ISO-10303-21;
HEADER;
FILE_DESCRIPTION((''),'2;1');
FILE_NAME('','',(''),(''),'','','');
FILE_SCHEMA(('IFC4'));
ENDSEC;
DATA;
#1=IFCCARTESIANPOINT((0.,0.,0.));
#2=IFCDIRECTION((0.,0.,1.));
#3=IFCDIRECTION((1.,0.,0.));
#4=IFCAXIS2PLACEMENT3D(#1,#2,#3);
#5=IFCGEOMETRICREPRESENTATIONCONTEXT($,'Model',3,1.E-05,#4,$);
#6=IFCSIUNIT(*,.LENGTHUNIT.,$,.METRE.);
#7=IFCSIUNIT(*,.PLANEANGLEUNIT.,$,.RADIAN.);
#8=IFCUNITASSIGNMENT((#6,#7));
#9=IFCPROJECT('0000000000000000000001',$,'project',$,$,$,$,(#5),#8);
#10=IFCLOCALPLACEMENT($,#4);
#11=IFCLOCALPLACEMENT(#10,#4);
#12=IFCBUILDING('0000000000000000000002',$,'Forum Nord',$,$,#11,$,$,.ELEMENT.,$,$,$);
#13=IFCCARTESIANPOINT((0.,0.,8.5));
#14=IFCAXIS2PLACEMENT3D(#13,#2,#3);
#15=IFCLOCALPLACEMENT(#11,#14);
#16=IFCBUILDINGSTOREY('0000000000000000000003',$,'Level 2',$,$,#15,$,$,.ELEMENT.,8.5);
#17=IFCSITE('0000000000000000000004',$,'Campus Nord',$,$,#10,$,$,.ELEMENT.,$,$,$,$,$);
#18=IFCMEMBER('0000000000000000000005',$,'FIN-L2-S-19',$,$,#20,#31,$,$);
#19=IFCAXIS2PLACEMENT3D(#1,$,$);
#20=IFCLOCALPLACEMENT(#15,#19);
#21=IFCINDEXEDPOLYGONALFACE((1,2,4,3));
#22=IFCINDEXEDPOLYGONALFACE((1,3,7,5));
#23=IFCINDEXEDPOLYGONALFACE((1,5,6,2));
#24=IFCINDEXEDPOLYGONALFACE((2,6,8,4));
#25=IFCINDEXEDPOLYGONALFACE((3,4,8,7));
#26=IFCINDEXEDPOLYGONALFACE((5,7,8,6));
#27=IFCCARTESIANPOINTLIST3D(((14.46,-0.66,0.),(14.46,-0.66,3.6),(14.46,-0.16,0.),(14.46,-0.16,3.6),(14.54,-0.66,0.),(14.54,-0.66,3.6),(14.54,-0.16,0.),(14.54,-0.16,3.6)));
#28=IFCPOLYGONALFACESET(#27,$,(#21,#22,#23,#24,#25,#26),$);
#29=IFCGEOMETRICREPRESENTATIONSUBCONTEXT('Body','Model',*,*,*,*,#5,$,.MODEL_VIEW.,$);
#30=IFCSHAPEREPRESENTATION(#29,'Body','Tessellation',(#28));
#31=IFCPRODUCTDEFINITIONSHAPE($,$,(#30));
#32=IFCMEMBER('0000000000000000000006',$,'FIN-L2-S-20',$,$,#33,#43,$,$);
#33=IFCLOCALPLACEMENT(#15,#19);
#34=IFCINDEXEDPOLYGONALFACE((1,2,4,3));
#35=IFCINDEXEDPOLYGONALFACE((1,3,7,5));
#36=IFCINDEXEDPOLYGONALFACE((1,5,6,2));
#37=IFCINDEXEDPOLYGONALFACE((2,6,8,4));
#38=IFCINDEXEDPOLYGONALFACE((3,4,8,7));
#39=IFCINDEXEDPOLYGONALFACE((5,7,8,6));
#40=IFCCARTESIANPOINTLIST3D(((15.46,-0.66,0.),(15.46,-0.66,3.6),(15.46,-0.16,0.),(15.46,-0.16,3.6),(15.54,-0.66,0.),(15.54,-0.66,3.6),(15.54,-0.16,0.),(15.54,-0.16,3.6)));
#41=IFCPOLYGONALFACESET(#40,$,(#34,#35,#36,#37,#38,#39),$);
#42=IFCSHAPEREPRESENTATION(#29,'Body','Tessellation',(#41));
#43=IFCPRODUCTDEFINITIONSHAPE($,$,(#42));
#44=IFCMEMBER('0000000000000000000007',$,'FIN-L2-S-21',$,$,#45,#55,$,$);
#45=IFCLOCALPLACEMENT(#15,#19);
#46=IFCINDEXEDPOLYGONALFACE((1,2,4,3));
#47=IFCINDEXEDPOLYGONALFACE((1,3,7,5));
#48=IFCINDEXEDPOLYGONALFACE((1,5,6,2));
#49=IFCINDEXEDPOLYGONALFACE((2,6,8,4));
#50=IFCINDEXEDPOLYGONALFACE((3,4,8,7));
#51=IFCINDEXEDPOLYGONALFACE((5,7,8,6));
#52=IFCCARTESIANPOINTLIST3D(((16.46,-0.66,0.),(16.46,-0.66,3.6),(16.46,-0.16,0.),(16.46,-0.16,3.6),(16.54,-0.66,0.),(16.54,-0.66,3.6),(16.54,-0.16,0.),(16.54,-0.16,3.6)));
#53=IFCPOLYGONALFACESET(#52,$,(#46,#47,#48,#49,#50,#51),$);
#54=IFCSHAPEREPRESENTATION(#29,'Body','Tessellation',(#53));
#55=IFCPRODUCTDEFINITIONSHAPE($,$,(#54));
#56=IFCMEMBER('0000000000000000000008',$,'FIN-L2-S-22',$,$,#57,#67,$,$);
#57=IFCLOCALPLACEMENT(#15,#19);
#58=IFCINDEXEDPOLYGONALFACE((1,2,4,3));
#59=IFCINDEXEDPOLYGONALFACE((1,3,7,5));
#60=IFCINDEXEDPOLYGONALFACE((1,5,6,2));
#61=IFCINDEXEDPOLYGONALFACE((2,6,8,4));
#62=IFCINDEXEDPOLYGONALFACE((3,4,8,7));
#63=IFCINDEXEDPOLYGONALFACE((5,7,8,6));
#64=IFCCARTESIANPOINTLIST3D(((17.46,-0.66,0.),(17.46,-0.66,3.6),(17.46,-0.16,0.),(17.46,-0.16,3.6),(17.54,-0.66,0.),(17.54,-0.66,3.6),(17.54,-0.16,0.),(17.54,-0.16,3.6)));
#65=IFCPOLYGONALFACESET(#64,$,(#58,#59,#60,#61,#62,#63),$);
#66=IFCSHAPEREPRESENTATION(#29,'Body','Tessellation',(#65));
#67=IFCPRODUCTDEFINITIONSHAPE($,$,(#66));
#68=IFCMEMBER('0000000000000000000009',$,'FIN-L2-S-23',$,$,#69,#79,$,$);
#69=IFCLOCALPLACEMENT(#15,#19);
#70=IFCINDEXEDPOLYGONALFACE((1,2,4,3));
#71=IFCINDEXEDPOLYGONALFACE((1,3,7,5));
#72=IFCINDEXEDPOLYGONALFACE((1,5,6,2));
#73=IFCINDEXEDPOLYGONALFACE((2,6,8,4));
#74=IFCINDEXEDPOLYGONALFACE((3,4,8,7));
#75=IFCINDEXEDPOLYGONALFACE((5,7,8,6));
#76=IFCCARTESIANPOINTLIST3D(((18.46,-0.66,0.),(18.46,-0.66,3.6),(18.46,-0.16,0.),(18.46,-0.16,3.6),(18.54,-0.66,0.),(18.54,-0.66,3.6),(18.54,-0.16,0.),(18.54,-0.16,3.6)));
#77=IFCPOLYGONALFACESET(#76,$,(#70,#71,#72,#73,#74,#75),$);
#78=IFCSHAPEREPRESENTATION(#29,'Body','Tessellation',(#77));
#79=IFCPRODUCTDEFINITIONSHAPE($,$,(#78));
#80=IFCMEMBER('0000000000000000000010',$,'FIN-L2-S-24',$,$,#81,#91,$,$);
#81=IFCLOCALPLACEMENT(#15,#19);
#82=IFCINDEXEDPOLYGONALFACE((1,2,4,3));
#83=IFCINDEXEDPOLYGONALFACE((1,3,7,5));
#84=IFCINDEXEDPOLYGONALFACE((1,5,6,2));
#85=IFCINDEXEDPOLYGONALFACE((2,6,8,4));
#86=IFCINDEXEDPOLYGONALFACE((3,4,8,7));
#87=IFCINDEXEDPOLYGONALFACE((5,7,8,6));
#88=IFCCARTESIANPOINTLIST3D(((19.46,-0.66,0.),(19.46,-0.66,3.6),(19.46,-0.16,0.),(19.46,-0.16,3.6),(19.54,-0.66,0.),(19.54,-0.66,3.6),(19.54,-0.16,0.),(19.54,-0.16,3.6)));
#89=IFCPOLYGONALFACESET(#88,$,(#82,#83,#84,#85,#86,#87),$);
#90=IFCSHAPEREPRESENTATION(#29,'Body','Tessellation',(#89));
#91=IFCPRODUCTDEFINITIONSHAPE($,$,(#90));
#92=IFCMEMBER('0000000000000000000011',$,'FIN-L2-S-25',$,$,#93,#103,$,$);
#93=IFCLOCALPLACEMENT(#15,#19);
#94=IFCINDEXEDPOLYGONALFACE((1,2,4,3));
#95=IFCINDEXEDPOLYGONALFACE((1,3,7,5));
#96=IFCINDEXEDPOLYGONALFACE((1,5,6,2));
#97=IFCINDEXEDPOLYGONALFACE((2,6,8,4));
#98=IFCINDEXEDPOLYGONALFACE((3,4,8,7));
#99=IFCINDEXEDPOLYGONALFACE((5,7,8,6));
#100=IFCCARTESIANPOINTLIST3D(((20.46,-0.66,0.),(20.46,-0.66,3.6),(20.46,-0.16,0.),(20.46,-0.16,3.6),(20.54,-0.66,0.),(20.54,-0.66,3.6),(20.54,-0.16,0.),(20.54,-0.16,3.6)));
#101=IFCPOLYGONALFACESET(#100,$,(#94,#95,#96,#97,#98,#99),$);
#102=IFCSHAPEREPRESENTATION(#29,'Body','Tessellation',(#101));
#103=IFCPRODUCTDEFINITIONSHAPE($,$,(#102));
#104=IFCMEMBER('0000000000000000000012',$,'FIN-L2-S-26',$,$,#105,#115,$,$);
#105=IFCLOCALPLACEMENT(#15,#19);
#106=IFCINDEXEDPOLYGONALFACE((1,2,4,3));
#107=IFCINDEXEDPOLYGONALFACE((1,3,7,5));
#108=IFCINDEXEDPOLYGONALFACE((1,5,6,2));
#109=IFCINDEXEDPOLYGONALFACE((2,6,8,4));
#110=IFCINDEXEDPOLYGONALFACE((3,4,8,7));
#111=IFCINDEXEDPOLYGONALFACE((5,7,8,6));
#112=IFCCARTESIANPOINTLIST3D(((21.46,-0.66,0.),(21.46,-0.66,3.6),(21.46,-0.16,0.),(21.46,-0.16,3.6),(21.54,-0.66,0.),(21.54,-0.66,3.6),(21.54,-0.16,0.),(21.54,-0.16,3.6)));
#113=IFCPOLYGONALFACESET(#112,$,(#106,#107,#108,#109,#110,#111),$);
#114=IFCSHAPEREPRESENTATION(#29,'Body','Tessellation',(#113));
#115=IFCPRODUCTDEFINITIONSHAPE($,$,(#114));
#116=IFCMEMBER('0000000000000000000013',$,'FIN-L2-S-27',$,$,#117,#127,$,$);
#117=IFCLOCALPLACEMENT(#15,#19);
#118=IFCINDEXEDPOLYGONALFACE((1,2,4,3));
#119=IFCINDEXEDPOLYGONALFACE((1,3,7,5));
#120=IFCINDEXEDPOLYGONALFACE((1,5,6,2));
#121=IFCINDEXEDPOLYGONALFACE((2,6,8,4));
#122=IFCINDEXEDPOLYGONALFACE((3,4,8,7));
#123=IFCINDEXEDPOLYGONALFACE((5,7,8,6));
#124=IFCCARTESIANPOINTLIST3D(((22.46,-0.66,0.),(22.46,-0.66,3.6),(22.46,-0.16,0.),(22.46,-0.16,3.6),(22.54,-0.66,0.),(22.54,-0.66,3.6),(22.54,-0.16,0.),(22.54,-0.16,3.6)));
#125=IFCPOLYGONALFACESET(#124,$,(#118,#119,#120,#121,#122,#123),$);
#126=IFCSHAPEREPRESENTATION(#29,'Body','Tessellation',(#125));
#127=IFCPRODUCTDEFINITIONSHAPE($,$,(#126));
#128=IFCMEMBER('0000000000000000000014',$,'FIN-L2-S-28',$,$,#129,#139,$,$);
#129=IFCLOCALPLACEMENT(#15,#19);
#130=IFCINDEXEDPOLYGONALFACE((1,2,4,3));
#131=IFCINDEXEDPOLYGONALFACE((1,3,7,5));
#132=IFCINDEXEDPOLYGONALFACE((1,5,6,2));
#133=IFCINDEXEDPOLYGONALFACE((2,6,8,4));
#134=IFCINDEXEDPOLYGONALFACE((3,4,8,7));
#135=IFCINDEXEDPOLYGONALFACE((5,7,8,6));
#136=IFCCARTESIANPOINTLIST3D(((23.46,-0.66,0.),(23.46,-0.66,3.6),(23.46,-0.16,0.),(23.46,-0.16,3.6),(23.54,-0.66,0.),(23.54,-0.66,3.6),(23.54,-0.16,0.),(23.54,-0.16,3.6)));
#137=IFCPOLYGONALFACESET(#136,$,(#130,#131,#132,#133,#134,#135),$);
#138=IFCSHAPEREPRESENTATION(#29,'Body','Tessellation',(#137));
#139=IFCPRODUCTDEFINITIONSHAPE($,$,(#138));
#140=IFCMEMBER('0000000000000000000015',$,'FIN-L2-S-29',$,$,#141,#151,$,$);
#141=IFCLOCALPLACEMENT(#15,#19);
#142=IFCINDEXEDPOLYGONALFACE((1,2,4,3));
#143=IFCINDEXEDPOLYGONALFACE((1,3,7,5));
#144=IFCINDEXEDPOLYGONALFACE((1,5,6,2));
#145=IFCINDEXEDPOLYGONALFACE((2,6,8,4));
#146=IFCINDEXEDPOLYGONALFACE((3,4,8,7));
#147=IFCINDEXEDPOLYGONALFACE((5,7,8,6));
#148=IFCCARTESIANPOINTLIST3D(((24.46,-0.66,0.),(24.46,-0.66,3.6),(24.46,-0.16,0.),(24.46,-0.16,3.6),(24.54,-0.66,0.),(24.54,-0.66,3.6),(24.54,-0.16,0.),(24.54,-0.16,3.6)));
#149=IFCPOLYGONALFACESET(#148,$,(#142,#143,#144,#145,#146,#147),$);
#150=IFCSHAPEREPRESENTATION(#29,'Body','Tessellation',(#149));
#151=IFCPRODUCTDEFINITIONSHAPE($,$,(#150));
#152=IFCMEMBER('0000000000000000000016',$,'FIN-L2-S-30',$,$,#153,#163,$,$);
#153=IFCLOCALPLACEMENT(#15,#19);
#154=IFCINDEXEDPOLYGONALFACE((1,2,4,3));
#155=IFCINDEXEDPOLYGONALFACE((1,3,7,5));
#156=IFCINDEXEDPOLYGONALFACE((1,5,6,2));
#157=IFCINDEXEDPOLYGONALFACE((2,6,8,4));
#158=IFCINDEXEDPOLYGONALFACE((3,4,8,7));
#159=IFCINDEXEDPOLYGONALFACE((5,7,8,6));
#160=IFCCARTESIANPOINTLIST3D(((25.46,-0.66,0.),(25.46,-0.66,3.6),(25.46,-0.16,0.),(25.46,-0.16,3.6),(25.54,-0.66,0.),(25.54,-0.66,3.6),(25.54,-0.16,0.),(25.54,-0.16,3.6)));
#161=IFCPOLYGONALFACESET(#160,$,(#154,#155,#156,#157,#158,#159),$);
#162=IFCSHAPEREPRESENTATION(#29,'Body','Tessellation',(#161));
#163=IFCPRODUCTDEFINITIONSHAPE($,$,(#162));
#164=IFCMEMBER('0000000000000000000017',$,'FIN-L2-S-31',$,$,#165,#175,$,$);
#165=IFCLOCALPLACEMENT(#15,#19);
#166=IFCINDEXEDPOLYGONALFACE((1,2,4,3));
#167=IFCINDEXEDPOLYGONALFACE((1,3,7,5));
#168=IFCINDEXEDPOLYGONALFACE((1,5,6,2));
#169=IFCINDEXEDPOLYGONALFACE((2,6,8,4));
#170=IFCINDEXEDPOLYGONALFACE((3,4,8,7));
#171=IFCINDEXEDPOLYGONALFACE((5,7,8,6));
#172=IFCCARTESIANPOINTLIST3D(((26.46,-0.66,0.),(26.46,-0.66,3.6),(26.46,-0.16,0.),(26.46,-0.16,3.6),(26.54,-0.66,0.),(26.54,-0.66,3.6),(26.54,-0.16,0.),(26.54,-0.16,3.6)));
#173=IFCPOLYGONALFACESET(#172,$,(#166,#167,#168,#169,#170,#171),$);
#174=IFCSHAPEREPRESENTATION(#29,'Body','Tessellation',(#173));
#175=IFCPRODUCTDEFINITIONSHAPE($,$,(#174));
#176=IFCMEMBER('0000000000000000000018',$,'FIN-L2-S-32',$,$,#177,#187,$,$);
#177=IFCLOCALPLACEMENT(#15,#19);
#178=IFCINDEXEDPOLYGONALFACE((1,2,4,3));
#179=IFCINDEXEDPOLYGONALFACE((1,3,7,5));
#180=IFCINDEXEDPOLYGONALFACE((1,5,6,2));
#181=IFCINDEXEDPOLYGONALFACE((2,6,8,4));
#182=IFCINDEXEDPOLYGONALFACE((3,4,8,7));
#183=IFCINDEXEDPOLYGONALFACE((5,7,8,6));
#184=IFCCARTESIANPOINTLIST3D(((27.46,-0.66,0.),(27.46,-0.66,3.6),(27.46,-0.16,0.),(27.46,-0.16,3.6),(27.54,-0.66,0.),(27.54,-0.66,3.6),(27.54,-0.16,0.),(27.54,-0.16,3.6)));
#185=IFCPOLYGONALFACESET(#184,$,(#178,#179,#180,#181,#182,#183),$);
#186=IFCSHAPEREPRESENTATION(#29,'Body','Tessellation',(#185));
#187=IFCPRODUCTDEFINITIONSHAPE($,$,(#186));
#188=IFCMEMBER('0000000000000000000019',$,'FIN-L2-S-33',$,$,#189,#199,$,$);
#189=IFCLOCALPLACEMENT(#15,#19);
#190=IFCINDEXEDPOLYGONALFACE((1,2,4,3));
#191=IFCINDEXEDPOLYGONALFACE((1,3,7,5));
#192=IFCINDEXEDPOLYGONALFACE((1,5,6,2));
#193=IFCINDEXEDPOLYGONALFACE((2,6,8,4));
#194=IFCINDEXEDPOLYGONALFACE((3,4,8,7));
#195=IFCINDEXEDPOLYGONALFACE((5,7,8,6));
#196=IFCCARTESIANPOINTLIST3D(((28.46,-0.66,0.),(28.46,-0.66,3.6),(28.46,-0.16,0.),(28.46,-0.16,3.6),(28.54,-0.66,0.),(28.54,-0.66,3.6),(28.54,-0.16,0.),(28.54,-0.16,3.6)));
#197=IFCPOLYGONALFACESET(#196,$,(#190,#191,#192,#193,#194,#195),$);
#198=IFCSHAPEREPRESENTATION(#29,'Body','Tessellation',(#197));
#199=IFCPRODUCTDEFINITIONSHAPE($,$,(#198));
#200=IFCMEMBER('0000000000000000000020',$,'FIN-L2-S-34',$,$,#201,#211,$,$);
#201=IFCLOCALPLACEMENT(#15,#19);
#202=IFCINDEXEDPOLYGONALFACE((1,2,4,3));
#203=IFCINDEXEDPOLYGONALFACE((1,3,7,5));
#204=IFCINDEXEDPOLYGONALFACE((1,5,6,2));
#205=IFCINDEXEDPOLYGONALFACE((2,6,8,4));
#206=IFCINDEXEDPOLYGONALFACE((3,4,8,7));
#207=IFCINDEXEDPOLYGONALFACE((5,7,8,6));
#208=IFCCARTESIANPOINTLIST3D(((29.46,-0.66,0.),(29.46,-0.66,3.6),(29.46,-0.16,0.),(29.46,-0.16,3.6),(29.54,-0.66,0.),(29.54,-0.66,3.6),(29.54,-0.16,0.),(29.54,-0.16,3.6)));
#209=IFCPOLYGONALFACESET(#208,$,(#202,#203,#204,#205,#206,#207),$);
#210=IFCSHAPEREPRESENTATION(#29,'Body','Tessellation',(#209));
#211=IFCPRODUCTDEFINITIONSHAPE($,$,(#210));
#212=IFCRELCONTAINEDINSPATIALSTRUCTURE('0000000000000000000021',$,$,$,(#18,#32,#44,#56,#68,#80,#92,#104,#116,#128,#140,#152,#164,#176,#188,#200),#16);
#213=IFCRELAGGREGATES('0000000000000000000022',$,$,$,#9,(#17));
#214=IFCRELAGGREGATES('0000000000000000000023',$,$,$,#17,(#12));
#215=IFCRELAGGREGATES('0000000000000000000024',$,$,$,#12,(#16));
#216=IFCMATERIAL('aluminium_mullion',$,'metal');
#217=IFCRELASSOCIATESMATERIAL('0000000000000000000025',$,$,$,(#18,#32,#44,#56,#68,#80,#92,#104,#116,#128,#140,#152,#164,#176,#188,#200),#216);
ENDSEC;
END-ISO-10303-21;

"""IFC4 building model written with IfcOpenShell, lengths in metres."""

from ifc_helpers import new_model, si_unit, frame, origin_with_axes, place, context, subcontext, project, spatial, polyline, outline, extrude, material, element, save


model = new_model("IFC4")

# Units and contexts
model_context = context("Model", 3, precision=1e-05, world=origin_with_axes())
body_context = subcontext(model_context, "Body", "Model", "MODEL_VIEW")
ifc_project = project(units=[si_unit("LENGTHUNIT", "METRE"), si_unit("PLANEANGLEUNIT", "RADIAN")], contexts=[model_context])

# Site, building, storey
site_placement = place(None, origin_with_axes())
site = spatial("IfcSite", under=ifc_project, at=site_placement, Name="Campus Nord", CompositionType="ELEMENT")
building_placement = place(site_placement, origin_with_axes())
building = spatial("IfcBuilding", under=site, at=building_placement, Name="Forum Nord", CompositionType="ELEMENT")
storey_placement = place(building_placement, frame((0.0, 0.0, 8.5), z_axis=(0.0, 0.0, 1.0), x_axis=(1.0, 0.0, 0.0)))
storey = spatial("IfcBuildingStorey", under=building, at=storey_placement, Name="Level 2", CompositionType="ELEMENT", Elevation=8.5)

# Members
ifc_material = material(Name="aluminium_mullion", Category="metal")
member_1_placement = place(storey_placement, origin_with_axes())
element("IfcMember", 1, at=member_1_placement, inside=storey, material=ifc_material, Name="FIN-L2-S-19", context=body_context, shape_type="SweptSolid", body=[
    extrude(outline(polyline([(14.46, -0.66), (14.54, -0.66), (14.54, -0.16), (14.46, -0.16), (14.46, -0.66)])), origin_with_axes(), (0.0, 0.0, 1.0), 3.6),
])
member_2_placement = place(storey_placement, origin_with_axes())
element("IfcMember", 2, at=member_2_placement, inside=storey, material=ifc_material, Name="FIN-L2-S-20", context=body_context, shape_type="SweptSolid", body=[
    extrude(outline(polyline([(15.46, -0.66), (15.54, -0.66), (15.54, -0.16), (15.46, -0.16), (15.46, -0.66)])), origin_with_axes(), (0.0, 0.0, 1.0), 3.6),
])
member_3_placement = place(storey_placement, origin_with_axes())
element("IfcMember", 3, at=member_3_placement, inside=storey, material=ifc_material, Name="FIN-L2-S-21", context=body_context, shape_type="SweptSolid", body=[
    extrude(outline(polyline([(16.46, -0.66), (16.54, -0.66), (16.54, -0.16), (16.46, -0.16), (16.46, -0.66)])), origin_with_axes(), (0.0, 0.0, 1.0), 3.6),
])
member_4_placement = place(storey_placement, origin_with_axes())
element("IfcMember", 4, at=member_4_placement, inside=storey, material=ifc_material, Name="FIN-L2-S-22", context=body_context, shape_type="SweptSolid", body=[
    extrude(outline(polyline([(17.46, -0.66), (17.54, -0.66), (17.54, -0.16), (17.46, -0.16), (17.46, -0.66)])), origin_with_axes(), (0.0, 0.0, 1.0), 3.6),
])
member_5_placement = place(storey_placement, origin_with_axes())
element("IfcMember", 5, at=member_5_placement, inside=storey, material=ifc_material, Name="FIN-L2-S-23", context=body_context, shape_type="SweptSolid", body=[
    extrude(outline(polyline([(18.46, -0.66), (18.54, -0.66), (18.54, -0.16), (18.46, -0.16), (18.46, -0.66)])), origin_with_axes(), (0.0, 0.0, 1.0), 3.6),
])
member_6_placement = place(storey_placement, origin_with_axes())
element("IfcMember", 6, at=member_6_placement, inside=storey, material=ifc_material, Name="FIN-L2-S-24", context=body_context, shape_type="SweptSolid", body=[
    extrude(outline(polyline([(19.46, -0.66), (19.54, -0.66), (19.54, -0.16), (19.46, -0.16), (19.46, -0.66)])), origin_with_axes(), (0.0, 0.0, 1.0), 3.6),
])
member_7_placement = place(storey_placement, origin_with_axes())
element("IfcMember", 7, at=member_7_placement, inside=storey, material=ifc_material, Name="FIN-L2-S-25", context=body_context, shape_type="SweptSolid", body=[
    extrude(outline(polyline([(20.46, -0.66), (20.54, -0.66), (20.54, -0.16), (20.46, -0.16), (20.46, -0.66)])), origin_with_axes(), (0.0, 0.0, 1.0), 3.6),
])
member_8_placement = place(storey_placement, origin_with_axes())
element("IfcMember", 8, at=member_8_placement, inside=storey, material=ifc_material, Name="FIN-L2-S-26", context=body_context, shape_type="SweptSolid", body=[
    extrude(outline(polyline([(21.46, -0.66), (21.54, -0.66), (21.54, -0.16), (21.46, -0.16), (21.46, -0.66)])), origin_with_axes(), (0.0, 0.0, 1.0), 3.6),
])
member_9_placement = place(storey_placement, origin_with_axes())
element("IfcMember", 9, at=member_9_placement, inside=storey, material=ifc_material, Name="FIN-L2-S-27", context=body_context, shape_type="SweptSolid", body=[
    extrude(outline(polyline([(22.46, -0.66), (22.54, -0.66), (22.54, -0.16), (22.46, -0.16), (22.46, -0.66)])), origin_with_axes(), (0.0, 0.0, 1.0), 3.6),
])
member_10_placement = place(storey_placement, origin_with_axes())
element("IfcMember", 10, at=member_10_placement, inside=storey, material=ifc_material, Name="FIN-L2-S-28", context=body_context, shape_type="SweptSolid", body=[
    extrude(outline(polyline([(23.46, -0.66), (23.54, -0.66), (23.54, -0.16), (23.46, -0.16), (23.46, -0.66)])), origin_with_axes(), (0.0, 0.0, 1.0), 3.6),
])
member_11_placement = place(storey_placement, origin_with_axes())
element("IfcMember", 11, at=member_11_placement, inside=storey, material=ifc_material, Name="FIN-L2-S-29", context=body_context, shape_type="SweptSolid", body=[
    extrude(outline(polyline([(24.46, -0.66), (24.54, -0.66), (24.54, -0.16), (24.46, -0.16), (24.46, -0.66)])), origin_with_axes(), (0.0, 0.0, 1.0), 3.6),
])
member_12_placement = place(storey_placement, origin_with_axes())
element("IfcMember", 12, at=member_12_placement, inside=storey, material=ifc_material, Name="FIN-L2-S-30", context=body_context, shape_type="SweptSolid", body=[
    extrude(outline(polyline([(25.46, -0.66), (25.54, -0.66), (25.54, -0.16), (25.46, -0.16), (25.46, -0.66)])), origin_with_axes(), (0.0, 0.0, 1.0), 3.6),
])
member_13_placement = place(storey_placement, origin_with_axes())
element("IfcMember", 13, at=member_13_placement, inside=storey, material=ifc_material, Name="FIN-L2-S-31", context=body_context, shape_type="SweptSolid", body=[
    extrude(outline(polyline([(26.46, -0.66), (26.54, -0.66), (26.54, -0.16), (26.46, -0.16), (26.46, -0.66)])), origin_with_axes(), (0.0, 0.0, 1.0), 3.6),
])
member_14_placement = place(storey_placement, origin_with_axes())
element("IfcMember", 14, at=member_14_placement, inside=storey, material=ifc_material, Name="FIN-L2-S-32", context=body_context, shape_type="SweptSolid", body=[
    extrude(outline(polyline([(27.46, -0.66), (27.54, -0.66), (27.54, -0.16), (27.46, -0.16), (27.46, -0.66)])), origin_with_axes(), (0.0, 0.0, 1.0), 3.6),
])
member_15_placement = place(storey_placement, origin_with_axes())
element("IfcMember", 15, at=member_15_placement, inside=storey, material=ifc_material, Name="FIN-L2-S-33", context=body_context, shape_type="SweptSolid", body=[
    extrude(outline(polyline([(28.46, -0.66), (28.54, -0.66), (28.54, -0.16), (28.46, -0.16), (28.46, -0.66)])), origin_with_axes(), (0.0, 0.0, 1.0), 3.6),
])
member_16_placement = place(storey_placement, origin_with_axes())
element("IfcMember", 16, at=member_16_placement, inside=storey, material=ifc_material, Name="FIN-L2-S-34", context=body_context, shape_type="SweptSolid", body=[
    extrude(outline(polyline([(29.46, -0.66), (29.54, -0.66), (29.54, -0.16), (29.46, -0.16), (29.46, -0.66)])), origin_with_axes(), (0.0, 0.0, 1.0), 3.6),
])

save(model, "model.ifc")
